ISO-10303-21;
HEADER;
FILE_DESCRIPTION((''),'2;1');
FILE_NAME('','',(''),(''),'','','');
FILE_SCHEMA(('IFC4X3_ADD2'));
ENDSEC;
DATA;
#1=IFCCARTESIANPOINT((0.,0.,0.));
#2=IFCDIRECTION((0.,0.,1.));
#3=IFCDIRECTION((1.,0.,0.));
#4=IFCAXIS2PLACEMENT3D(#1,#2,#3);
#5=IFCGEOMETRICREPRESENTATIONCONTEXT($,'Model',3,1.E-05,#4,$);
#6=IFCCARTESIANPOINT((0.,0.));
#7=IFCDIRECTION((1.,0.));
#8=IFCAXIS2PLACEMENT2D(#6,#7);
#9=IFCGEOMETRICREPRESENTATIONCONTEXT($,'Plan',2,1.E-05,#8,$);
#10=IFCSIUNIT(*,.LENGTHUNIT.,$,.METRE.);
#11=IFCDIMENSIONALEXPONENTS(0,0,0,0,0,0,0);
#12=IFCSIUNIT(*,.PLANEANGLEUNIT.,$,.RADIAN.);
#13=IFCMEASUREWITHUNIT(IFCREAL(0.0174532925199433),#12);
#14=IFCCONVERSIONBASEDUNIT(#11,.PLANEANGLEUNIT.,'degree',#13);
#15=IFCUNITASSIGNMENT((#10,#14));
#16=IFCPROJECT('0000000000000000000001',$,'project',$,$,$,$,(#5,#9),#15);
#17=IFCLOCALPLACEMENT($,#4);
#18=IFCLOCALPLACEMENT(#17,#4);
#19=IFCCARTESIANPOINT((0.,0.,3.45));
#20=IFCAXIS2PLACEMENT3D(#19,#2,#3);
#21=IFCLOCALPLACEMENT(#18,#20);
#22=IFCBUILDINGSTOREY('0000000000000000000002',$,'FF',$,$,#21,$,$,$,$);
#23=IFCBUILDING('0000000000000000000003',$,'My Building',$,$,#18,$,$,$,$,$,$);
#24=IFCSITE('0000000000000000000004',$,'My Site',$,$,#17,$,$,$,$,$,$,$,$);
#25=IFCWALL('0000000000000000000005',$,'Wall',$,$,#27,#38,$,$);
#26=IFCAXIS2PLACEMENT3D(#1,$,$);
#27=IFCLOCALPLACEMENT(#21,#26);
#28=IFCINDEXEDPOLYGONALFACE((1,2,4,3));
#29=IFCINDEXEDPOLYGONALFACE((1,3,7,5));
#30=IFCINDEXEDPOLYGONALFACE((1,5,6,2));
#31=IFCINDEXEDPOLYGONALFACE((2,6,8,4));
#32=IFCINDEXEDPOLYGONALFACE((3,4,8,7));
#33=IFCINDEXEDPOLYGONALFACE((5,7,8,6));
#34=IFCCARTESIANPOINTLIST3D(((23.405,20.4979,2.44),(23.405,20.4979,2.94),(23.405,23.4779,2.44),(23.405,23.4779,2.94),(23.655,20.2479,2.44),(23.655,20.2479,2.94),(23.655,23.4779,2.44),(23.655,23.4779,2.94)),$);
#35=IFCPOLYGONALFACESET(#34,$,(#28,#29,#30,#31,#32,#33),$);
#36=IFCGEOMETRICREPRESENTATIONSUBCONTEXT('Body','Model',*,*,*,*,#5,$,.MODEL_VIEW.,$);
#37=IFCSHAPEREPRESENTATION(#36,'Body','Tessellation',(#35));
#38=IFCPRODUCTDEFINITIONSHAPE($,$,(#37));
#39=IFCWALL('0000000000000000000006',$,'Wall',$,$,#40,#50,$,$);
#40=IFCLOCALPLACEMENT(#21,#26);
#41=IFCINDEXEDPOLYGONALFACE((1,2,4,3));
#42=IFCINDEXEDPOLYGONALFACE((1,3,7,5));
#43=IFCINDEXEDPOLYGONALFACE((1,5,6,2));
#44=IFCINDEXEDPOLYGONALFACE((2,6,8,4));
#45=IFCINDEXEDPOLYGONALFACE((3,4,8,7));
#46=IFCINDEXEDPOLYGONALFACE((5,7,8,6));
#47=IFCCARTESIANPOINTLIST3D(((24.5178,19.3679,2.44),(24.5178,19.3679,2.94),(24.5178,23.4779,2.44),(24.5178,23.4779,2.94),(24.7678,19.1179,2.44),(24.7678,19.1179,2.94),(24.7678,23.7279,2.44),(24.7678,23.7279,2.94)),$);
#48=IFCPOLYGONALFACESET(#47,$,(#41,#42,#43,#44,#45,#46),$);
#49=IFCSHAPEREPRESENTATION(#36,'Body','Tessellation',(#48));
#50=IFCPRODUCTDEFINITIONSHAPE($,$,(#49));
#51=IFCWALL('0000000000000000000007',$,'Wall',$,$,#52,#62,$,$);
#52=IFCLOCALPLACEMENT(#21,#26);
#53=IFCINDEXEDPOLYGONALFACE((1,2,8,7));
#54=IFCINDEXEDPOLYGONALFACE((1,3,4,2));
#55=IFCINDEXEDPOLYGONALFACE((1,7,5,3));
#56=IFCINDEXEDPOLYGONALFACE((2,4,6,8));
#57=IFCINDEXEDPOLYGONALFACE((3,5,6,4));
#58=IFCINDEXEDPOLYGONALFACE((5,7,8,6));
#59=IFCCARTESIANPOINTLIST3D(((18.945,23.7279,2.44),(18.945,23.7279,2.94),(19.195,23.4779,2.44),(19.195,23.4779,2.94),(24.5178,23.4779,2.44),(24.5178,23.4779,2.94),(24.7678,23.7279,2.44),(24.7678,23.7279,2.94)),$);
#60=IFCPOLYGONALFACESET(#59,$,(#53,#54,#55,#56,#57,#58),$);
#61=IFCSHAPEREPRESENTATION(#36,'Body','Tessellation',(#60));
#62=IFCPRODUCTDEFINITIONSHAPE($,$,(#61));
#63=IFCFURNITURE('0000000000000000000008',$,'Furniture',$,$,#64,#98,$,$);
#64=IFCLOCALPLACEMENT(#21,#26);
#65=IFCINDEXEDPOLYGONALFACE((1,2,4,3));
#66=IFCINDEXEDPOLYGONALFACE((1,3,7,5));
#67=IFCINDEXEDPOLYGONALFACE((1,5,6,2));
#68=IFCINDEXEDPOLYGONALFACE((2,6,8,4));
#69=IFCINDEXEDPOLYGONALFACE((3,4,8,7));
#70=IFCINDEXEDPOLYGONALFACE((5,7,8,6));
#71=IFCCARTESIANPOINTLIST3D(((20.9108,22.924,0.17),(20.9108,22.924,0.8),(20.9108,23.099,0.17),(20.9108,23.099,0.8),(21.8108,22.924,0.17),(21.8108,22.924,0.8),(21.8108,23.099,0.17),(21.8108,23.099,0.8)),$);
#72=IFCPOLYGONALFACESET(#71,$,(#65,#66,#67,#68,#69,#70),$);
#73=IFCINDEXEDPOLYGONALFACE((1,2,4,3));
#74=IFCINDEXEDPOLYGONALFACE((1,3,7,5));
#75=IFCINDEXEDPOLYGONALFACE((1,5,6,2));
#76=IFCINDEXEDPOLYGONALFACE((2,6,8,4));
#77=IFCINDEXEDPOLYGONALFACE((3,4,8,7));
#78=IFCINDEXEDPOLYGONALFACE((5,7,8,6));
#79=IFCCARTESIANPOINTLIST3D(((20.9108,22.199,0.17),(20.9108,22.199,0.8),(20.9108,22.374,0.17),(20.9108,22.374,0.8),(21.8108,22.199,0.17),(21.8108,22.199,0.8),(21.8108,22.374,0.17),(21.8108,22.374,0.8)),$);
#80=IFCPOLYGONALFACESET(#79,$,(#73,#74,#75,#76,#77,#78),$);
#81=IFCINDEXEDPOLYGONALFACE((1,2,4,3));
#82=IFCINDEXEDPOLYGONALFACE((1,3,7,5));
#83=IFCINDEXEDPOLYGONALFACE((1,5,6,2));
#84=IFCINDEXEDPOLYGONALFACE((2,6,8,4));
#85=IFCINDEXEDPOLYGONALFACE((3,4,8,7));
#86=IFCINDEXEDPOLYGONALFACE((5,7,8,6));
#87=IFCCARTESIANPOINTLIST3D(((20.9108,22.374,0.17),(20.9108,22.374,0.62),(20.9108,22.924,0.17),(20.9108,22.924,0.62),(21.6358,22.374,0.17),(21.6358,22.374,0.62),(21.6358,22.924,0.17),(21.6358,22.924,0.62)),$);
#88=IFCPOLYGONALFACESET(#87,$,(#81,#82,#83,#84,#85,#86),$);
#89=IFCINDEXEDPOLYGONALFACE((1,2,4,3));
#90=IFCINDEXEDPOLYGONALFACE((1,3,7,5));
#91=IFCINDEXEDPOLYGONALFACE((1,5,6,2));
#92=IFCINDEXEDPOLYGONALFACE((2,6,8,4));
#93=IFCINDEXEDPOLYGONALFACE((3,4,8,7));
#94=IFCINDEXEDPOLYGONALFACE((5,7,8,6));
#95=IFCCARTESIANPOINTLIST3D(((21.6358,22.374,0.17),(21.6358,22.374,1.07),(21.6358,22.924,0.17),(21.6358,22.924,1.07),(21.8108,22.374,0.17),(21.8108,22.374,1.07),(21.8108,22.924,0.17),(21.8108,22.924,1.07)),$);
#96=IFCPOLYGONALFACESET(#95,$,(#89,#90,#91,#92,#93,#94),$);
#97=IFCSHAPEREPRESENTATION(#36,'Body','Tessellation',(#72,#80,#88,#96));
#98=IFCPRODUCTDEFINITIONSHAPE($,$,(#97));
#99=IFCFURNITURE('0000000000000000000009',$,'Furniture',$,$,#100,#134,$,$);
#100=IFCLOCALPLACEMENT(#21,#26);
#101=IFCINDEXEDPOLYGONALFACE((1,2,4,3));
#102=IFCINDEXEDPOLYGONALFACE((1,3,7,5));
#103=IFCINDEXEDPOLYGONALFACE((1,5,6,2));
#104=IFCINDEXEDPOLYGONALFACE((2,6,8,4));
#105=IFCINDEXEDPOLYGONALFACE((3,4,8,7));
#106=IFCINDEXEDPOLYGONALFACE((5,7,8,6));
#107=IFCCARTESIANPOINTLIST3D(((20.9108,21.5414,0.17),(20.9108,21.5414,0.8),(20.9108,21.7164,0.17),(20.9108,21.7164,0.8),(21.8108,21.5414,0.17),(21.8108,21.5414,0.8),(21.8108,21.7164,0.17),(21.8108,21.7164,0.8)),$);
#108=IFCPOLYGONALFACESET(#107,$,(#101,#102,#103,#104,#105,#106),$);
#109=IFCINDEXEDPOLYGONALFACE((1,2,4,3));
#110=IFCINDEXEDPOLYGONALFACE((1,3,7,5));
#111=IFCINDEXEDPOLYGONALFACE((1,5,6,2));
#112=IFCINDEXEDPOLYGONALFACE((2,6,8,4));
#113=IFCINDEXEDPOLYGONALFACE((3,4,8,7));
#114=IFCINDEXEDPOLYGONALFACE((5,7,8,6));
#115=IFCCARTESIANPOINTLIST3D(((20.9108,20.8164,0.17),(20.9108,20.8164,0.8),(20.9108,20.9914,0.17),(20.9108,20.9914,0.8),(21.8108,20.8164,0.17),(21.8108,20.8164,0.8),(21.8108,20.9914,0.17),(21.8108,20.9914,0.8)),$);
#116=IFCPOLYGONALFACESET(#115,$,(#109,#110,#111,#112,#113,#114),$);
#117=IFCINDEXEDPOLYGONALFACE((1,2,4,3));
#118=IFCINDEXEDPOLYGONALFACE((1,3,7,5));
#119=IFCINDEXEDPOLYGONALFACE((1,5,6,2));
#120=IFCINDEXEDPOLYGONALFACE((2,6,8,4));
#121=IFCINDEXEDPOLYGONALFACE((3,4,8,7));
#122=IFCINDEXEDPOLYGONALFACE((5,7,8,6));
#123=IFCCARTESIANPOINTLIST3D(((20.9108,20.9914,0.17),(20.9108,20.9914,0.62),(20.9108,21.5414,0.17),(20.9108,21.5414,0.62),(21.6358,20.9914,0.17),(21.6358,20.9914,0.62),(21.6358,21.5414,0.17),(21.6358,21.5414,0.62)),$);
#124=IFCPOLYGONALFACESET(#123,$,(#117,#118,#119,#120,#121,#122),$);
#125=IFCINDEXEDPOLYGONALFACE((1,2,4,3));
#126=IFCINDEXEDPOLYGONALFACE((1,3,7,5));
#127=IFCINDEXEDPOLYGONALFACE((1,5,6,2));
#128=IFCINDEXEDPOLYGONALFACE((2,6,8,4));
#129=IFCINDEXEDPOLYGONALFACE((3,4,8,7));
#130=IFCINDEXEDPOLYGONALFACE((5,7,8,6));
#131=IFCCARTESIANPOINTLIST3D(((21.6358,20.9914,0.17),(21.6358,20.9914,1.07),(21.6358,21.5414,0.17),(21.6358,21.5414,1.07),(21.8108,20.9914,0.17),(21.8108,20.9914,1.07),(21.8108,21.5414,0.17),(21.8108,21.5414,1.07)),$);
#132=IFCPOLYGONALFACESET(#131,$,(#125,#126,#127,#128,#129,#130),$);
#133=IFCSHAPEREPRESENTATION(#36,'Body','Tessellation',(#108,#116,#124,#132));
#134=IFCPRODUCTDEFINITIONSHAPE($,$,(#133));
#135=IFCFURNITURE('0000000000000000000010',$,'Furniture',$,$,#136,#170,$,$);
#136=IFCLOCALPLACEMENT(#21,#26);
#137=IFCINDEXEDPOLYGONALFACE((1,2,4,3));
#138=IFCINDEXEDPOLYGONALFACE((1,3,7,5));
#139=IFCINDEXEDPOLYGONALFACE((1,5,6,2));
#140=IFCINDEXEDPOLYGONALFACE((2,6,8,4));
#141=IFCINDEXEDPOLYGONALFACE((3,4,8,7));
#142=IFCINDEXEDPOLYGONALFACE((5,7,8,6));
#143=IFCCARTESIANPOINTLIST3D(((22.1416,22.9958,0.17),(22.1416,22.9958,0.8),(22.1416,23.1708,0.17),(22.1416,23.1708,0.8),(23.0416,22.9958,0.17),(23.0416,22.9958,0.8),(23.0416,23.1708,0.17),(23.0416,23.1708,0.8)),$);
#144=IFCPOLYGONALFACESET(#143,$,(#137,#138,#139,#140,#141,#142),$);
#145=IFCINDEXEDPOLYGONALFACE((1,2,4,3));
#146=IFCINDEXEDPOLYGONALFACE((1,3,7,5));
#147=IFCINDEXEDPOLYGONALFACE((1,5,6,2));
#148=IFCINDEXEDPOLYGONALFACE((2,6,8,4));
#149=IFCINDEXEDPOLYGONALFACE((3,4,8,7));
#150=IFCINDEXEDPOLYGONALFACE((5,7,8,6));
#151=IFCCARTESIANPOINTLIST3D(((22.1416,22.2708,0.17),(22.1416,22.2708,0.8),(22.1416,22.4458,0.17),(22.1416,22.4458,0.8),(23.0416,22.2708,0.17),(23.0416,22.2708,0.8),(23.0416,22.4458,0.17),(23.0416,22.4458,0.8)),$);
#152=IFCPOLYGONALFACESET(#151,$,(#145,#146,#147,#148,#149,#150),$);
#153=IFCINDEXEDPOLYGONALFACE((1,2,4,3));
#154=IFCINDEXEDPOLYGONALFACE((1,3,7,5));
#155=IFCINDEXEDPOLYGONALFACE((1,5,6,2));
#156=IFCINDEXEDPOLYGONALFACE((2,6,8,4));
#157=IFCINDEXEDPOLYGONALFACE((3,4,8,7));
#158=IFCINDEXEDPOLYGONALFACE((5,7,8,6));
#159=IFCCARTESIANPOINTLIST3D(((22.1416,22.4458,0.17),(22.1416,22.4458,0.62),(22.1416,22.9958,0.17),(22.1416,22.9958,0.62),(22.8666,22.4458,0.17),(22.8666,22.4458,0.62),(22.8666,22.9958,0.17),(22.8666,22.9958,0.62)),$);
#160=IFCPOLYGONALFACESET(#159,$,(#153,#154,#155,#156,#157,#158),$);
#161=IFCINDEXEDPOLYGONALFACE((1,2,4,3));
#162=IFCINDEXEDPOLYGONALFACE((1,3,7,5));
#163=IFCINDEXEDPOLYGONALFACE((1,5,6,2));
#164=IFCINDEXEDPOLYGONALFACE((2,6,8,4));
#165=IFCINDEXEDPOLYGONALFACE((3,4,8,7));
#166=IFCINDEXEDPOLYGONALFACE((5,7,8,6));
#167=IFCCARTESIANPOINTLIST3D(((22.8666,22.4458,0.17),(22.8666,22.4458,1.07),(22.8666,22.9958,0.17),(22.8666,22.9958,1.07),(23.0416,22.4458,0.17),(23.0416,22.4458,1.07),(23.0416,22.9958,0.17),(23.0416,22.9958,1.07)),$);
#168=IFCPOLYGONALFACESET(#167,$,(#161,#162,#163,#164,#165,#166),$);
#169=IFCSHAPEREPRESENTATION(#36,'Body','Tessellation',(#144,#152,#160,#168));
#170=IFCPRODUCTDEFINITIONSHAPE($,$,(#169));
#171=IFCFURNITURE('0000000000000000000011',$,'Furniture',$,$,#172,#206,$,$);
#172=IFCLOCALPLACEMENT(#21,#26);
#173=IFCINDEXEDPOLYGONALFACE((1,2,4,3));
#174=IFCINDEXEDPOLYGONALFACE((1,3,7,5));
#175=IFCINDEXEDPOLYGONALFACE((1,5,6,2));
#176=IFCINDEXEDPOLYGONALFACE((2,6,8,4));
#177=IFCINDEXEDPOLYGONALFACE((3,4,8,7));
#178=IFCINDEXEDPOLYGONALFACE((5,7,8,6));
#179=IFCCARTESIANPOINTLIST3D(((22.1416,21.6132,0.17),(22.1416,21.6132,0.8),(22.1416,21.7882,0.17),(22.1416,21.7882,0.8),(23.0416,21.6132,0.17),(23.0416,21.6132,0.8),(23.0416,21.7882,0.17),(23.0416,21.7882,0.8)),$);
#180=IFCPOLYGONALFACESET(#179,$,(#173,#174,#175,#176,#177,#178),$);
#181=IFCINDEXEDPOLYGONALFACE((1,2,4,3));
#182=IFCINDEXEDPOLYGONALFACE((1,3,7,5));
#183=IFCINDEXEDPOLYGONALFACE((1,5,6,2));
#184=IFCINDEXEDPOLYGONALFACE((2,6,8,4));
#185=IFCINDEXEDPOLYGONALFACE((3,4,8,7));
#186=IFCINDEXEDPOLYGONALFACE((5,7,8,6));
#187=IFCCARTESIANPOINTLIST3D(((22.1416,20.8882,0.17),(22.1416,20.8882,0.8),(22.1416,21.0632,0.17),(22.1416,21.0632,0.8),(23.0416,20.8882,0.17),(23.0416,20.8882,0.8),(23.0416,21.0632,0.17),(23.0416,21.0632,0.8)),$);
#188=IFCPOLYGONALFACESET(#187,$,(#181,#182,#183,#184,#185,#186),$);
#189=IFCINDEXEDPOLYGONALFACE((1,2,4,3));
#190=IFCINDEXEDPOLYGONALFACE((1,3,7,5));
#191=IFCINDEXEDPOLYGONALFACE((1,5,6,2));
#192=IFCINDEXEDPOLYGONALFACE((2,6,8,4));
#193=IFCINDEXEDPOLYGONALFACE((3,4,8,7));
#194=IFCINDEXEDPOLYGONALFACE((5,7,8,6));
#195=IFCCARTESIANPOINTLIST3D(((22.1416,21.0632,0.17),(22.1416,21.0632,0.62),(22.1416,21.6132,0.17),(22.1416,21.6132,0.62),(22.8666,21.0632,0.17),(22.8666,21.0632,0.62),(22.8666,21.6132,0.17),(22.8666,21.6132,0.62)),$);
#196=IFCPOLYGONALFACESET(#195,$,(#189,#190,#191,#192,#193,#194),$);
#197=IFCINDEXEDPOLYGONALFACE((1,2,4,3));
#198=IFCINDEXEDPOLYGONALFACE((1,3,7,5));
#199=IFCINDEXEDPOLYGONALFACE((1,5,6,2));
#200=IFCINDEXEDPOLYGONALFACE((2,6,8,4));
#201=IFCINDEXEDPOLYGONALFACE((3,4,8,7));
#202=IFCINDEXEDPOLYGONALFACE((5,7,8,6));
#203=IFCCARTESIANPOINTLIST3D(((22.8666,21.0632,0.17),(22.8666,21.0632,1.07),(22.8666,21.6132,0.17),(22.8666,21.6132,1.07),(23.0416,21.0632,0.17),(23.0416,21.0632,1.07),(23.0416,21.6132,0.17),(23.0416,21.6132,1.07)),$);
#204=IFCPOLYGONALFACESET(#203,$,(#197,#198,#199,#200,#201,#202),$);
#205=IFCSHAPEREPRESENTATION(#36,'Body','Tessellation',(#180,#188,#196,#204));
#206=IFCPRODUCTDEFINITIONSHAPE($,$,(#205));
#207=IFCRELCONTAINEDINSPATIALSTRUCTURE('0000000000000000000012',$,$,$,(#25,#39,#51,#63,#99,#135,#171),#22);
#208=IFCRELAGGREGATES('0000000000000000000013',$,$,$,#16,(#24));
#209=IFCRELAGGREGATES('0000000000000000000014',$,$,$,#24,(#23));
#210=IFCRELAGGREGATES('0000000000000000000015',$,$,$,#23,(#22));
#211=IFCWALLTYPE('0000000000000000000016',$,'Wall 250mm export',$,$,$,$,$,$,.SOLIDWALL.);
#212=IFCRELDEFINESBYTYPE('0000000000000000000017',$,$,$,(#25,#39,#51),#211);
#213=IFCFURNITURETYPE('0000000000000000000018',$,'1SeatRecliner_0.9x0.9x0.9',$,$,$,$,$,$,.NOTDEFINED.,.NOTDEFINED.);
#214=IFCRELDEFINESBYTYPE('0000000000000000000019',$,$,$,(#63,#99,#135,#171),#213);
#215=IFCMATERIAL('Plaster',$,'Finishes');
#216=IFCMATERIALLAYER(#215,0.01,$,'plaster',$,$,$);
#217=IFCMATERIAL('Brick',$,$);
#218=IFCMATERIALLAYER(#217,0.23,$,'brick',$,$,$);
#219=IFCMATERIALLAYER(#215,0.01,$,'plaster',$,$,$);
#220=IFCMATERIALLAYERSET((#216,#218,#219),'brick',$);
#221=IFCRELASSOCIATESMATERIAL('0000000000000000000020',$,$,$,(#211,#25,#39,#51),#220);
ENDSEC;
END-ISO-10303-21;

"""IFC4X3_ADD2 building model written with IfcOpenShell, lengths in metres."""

from ifc_helpers import new_model, entity, si_unit, converted_unit, frame, origin_with_axes, origin_2d_with_axis, place, context, subcontext, project, spatial, line, indexed_curve, outline, extrude, shape, source, transform, mapped, material, layer, layer_set, layer_usage, type_object, type_shapes, element, save


model = new_model("IFC4X3_ADD2")

# Units and contexts
model_context = context("Model", 3, precision=1e-05, world=origin_with_axes())
plan_context = context("Plan", 2, precision=1e-05, world=origin_2d_with_axis())
body_context_1 = subcontext(model_context, "Body", "Model", "MODEL_VIEW")
body_context_2 = subcontext(plan_context, "Body", "Plan", "PLAN_VIEW")
ifc_project = project(units=[si_unit("LENGTHUNIT", "METRE"), converted_unit("PLANEANGLEUNIT", "degree", entity("IfcReal", 0.0174532925199433), si_unit("PLANEANGLEUNIT", "RADIAN"), dimensions=[0, 0, 0, 0, 0, 0, 0])], contexts=[model_context, plan_context])

# Site, building, storey
site_placement = place(None, origin_with_axes())
site = spatial("IfcSite", under=ifc_project, at=site_placement, Name="My Site")
building_placement = place(site_placement, origin_with_axes())
building = spatial("IfcBuilding", under=site, at=building_placement, Name="My Building")
storey_placement = place(building_placement, frame((0.0, 0.0, 3.45), z_axis=(0.0, 0.0, 1.0), x_axis=(1.0, 0.0, 0.0)))
storey = spatial("IfcBuildingStorey", under=building, at=storey_placement, Name="FF")

# Shared definitions
ifc_material_1 = material(Name="Plaster", Category="Finishes")
ifc_layer_1 = layer(ifc_material_1, 0.01, Name="plaster")
ifc_material_2 = material(Name="Brick")
ifc_layer_2 = layer(ifc_material_2, 0.23, Name="brick")
ifc_layer_3 = layer(ifc_material_1, 0.01, Name="plaster")
ifc_layer_set_1 = layer_set([ifc_layer_1, ifc_layer_2, ifc_layer_3], Name="brick")
wall_type_1 = type_object("IfcWallType", Name="Wall 250mm export", PredefinedType="SOLIDWALL", material=ifc_layer_set_1)

# Walls
ifc_layer_usage_1 = layer_usage(ifc_layer_set_1, "AXIS2", "POSITIVE", 0.0)
wall_1_placement = place(storey_placement, frame((23.655, 20.2479, 2.44), z_axis=(0.0, 0.0, 1.0), x_axis=(0.0, 1.0, 0.0)))
element("IfcWall", 1, at=wall_1_placement, inside=storey, type_object=wall_type_1, material=ifc_layer_usage_1, Name="Wall", context=body_context_1, shape_type="SweptSolid", body=[
    extrude(outline(indexed_curve([(0.0, 0.0), (0.25, 0.25), (3.23, 0.25), (3.23, 0.0)], segments=[line(1, 2, 3, 4, 1)])), origin_with_axes(), (0.0, 0.0, 1.0), 0.5),
])
ifc_layer_usage_2 = layer_usage(ifc_layer_set_1, "AXIS2", "POSITIVE", 0.0)
wall_2_placement = place(storey_placement, frame((24.7678, 19.1179, 2.44), z_axis=(0.0, 0.0, 1.0), x_axis=(0.0, 1.0, 0.0)))
element("IfcWall", 2, at=wall_2_placement, inside=storey, type_object=wall_type_1, material=ifc_layer_usage_2, Name="Wall", context=body_context_1, shape_type="SweptSolid", body=[
    extrude(outline(indexed_curve([(0.0, 0.0), (0.25, 0.25), (4.36, 0.25), (4.61, 0.0)], segments=[line(1, 2, 3, 4, 1)])), origin_with_axes(), (0.0, 0.0, 1.0), 0.5),
])
ifc_layer_usage_3 = layer_usage(ifc_layer_set_1, "AXIS2", "POSITIVE", 0.0)
wall_3_placement = place(storey_placement, frame((19.195, 23.4779, 2.44), z_axis=(0.0, 0.0, 1.0), x_axis=(1.0, 0.0, 0.0)))
element("IfcWall", 3, at=wall_3_placement, inside=storey, type_object=wall_type_1, material=ifc_layer_usage_3, Name="Wall", context=body_context_1, shape_type="SweptSolid", body=[
    extrude(outline(indexed_curve([(0.0, 0.0), (-0.25, 0.25), (5.5728, 0.25), (5.3228, 0.0)], segments=[line(1, 2, 3, 4, 1)])), origin_with_axes(), (0.0, 0.0, 1.0), 0.5),
])

# Furniture
furniture_type = type_object("IfcFurnitureType", Name="1SeatRecliner_0.9x0.9x0.9", AssemblyPlace="NOTDEFINED", PredefinedType="NOTDEFINED")
shared_shape_1 = source(origin_with_axes(), body_context_1, "Body", "SweptSolid", [
    extrude(outline(indexed_curve([(0.0, 0.0), (0.175, 0.0), (0.175, 0.9), (0.0, 0.9), (0.0, 0.0)])), frame((-0.45, -0.9, 0.0), z_axis=(0.0, 0.0, 1.0), x_axis=(1.0, 0.0, 0.0)), (0.0, 0.0, 1.0), 0.63),
    extrude(outline(indexed_curve([(0.0, 0.9), (0.175, 0.9), (0.175, 0.0), (0.0, 0.0), (0.0, 0.9)])), frame((0.275, -0.9, 0.0), z_axis=(0.0, 0.0, 1.0), x_axis=(1.0, 0.0, 0.0)), (0.0, 0.0, 1.0), 0.63),
    extrude(outline(indexed_curve([(0.175, 0.725), (0.725, 0.725), (0.725, 0.0), (0.175, 0.0), (0.175, 0.725)])), frame((-0.45, -0.9, 0.0), z_axis=(0.0, 0.0, 1.0), x_axis=(1.0, 0.0, 0.0)), (0.0, 0.0, 1.0), 0.45),
    extrude(outline(indexed_curve([(0.175, 0.9), (0.725, 0.9), (0.725, 0.725), (0.175, 0.725), (0.175, 0.9)])), frame((-0.45, -0.9, 0.0), z_axis=(0.0, 0.0, 1.0), x_axis=(1.0, 0.0, 0.0)), (0.0, 0.0, 1.0), 0.9),
])
shared_shape_2 = source(origin_with_axes(), body_context_2, "Body", "Annotation2D", [
    entity("IfcGeometricCurveSet", [entity("IfcIndexedPolyCurve", entity("IfcCartesianPointList2D", [[0.275, -0.175], [0.275, -0.9], [0.45, -0.9], [0.45, 0.0], [0.275, 0.0], [0.275, -0.9], [-0.275, -0.9], [-0.275, 0.0], [-0.275, -0.175], [0.275, -0.175], [0.275, 0.0], [-0.275, 0.0], [-0.45, 0.0], [-0.45, -0.9], [-0.275, -0.9], [-0.275, -0.175]]))]),
])
type_shapes(furniture_type, [shared_shape_1, shared_shape_2])
for number, where, z_axis, x_axis, name in (
    (4, (21.8108, 22.649, 0.17), (0.0, 0.0, 1.0), (0.0, -1.0, 0.0), "Furniture"),
    (5, (21.8108, 21.2664, 0.17), (0.0, 0.0, 1.0), (0.0, -1.0, 0.0), "Furniture"),
    (6, (23.0416, 22.7208, 0.17), (0.0, 0.0, 1.0), (0.0, -1.0, 0.0), "Furniture"),
    (7, (23.0416, 21.3382, 0.17), (0.0, 0.0, 1.0), (0.0, -1.0, 0.0), "Furniture"),
):
    element("IfcFurniture", number, at=place(storey_placement, frame(where, z_axis=z_axis, x_axis=x_axis)), inside=storey, type_object=furniture_type, Name=name, shapes=[
        shape(body_context_1, "Body", "MappedRepresentation", [mapped(shared_shape_1, transform((0.0, 0.0, 0.0), x_axis=(1.0, 0.0, 0.0), y_axis=(0.0, 1.0, 0.0), z_axis=(0.0, 0.0, 1.0), scale=1.0))]),
        shape(body_context_2, "Body", "MappedRepresentation", [mapped(shared_shape_2, transform((0.0, 0.0, 0.0), x_axis=(1.0, 0.0, 0.0), y_axis=(0.0, 1.0, 0.0), z_axis=(0.0, 0.0, 1.0), scale=1.0))]),
    ])

save(model, "model.ifc")
